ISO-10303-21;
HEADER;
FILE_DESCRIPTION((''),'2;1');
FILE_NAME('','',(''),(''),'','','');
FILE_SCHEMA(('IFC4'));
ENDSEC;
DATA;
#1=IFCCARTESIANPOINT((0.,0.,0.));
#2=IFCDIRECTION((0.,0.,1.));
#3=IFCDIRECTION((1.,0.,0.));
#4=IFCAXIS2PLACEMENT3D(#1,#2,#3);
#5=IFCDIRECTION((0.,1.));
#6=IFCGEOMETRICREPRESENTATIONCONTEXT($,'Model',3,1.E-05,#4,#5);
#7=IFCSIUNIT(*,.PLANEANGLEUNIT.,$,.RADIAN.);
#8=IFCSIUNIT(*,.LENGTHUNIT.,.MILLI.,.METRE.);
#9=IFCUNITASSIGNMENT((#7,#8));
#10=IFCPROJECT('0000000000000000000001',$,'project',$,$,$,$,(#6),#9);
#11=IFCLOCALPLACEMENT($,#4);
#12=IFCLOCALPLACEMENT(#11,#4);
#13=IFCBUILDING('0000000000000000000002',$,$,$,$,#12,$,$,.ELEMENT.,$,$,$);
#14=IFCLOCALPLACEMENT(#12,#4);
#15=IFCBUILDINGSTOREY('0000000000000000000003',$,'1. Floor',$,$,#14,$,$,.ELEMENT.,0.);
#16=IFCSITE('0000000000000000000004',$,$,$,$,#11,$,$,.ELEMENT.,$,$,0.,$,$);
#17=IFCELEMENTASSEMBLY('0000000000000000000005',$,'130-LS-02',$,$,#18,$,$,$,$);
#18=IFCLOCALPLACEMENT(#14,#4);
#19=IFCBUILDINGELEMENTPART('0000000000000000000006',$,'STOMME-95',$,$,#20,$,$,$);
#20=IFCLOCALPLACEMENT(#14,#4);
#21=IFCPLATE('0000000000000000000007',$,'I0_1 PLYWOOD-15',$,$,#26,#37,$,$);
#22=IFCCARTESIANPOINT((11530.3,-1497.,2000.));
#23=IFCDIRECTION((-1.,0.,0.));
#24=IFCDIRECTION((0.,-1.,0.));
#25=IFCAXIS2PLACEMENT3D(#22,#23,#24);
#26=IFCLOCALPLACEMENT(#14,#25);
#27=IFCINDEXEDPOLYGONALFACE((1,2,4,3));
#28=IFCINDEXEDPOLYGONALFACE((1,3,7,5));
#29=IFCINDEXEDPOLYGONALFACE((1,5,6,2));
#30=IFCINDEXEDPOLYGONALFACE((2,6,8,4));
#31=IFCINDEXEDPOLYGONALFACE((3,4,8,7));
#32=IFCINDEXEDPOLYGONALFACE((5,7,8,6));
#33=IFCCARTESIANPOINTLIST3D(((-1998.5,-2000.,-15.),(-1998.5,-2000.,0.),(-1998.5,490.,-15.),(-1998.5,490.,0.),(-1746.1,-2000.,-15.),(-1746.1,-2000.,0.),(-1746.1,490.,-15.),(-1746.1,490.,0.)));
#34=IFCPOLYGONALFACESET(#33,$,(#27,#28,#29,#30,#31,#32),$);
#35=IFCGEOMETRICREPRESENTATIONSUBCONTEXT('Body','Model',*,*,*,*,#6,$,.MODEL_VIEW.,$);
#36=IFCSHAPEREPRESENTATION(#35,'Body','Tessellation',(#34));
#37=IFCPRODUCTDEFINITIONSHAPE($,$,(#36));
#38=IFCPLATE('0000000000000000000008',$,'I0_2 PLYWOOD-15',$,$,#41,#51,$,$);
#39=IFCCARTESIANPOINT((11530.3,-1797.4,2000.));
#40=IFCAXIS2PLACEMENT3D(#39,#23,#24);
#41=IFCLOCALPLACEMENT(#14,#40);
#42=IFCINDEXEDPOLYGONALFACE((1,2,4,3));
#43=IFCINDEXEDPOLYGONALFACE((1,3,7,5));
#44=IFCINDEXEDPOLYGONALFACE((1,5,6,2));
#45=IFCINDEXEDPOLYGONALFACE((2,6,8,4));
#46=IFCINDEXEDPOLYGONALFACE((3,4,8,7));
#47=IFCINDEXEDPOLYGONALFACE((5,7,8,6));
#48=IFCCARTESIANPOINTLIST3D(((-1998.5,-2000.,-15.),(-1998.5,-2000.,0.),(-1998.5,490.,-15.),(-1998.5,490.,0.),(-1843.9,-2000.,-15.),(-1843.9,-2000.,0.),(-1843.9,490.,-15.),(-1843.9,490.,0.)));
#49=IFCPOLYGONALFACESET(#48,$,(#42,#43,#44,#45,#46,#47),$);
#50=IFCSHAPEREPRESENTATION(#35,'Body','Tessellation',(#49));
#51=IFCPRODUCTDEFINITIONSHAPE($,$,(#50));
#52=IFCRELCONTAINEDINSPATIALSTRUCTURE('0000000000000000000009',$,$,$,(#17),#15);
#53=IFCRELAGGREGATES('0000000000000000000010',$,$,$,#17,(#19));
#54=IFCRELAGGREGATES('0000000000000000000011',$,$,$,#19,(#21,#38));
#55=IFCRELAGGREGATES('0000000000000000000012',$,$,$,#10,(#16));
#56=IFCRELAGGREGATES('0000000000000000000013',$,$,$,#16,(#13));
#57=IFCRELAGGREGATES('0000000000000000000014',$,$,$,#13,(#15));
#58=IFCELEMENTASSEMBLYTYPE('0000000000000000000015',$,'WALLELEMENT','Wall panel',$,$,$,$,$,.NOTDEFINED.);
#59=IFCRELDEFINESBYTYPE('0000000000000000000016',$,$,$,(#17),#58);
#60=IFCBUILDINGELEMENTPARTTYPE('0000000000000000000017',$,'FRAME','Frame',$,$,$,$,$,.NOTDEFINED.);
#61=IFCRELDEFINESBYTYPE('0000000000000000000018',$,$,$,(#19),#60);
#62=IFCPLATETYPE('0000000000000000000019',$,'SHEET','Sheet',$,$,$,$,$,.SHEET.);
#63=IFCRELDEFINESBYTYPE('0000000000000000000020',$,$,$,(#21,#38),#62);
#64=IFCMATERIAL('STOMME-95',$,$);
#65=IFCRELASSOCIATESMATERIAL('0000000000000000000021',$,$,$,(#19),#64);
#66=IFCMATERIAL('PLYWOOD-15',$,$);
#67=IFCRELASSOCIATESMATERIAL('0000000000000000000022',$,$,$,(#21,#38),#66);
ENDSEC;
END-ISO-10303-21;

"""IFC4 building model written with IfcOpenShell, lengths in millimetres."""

from ifc_helpers import new_model, si_unit, direction, frame, origin_with_axes, origin_2d_with_axis, place, context, subcontext, project, spatial, rectangle, extrude, material, type_object, element, aggregate, save


model = new_model("IFC4")

# Units and contexts
model_context = context("Model", 3, precision=1e-05, world=origin_with_axes(), true_north=direction((0.0, 1.0)))
body_context = subcontext(model_context, "Body", "Model", "MODEL_VIEW")
ifc_project = project(units=[si_unit("PLANEANGLEUNIT", "RADIAN"), si_unit("LENGTHUNIT", "METRE", prefix="MILLI")], contexts=[model_context])

# Site, building, storey
site_placement = place(None, origin_with_axes())
site = spatial("IfcSite", under=ifc_project, at=site_placement, CompositionType="ELEMENT", RefElevation=0.0)
building_placement = place(site_placement, origin_with_axes())
building = spatial("IfcBuilding", under=site, at=building_placement, CompositionType="ELEMENT")
storey_placement = place(building_placement, origin_with_axes())
storey = spatial("IfcBuildingStorey", under=building, at=storey_placement, Name="1. Floor", CompositionType="ELEMENT", Elevation=0.0)

# Shared definitions
element_assembly_type = type_object("IfcElementAssemblyType", Name="WALLELEMENT", Description="Wall panel", PredefinedType="NOTDEFINED")

# Element assembly, building element part
assembly_1_placement = place(storey_placement, origin_with_axes())
assembly_1 = element("IfcElementAssembly", 1, at=assembly_1_placement, inside=storey, type_object=element_assembly_type, Name="130-LS-02")
ifc_material_1 = material(Name="STOMME-95")
building_element_part_type_1 = type_object("IfcBuildingElementPartType", Name="FRAME", Description="Frame", PredefinedType="NOTDEFINED")
building_element_part_1_placement = place(storey_placement, origin_with_axes())
building_element_part_1 = element("IfcBuildingElementPart", 2, at=building_element_part_1_placement, type_object=building_element_part_type_1, material=ifc_material_1, Name="STOMME-95")
aggregate(assembly_1, [building_element_part_1])

# Plates
ifc_material_2 = material(Name="PLYWOOD-15")
plate_type_1 = type_object("IfcPlateType", Name="SHEET", Description="Sheet", PredefinedType="SHEET")
plate_1_placement = place(storey_placement, frame((11530.3, -1497.0, 2000.0), z_axis=(-1.0, 0.0, 0.0), x_axis=(0.0, -1.0, 0.0)))
plate_1 = element("IfcPlate", 3, at=plate_1_placement, type_object=plate_type_1, material=ifc_material_2, Name="I0_1 PLYWOOD-15", context=body_context, shape_type="SweptSolid", body=[
    extrude(rectangle(XDim=15.0, YDim=252.4, at=origin_2d_with_axis()), frame((-1872.3, -2000.0, -7.5), z_axis=(0.0, 1.0, 0.0), x_axis=(0.0, 0.0, 1.0)), (0.0, 0.0, 1.0), 2490.0),
])
plate_2_placement = place(storey_placement, frame((11530.3, -1797.4, 2000.0), z_axis=(-1.0, 0.0, 0.0), x_axis=(0.0, -1.0, 0.0)))
plate_2 = element("IfcPlate", 4, at=plate_2_placement, type_object=plate_type_1, material=ifc_material_2, Name="I0_2 PLYWOOD-15", context=body_context, shape_type="SweptSolid", body=[
    extrude(rectangle(XDim=15.0, YDim=154.6, at=origin_2d_with_axis()), frame((-1921.2, -2000.0, -7.5), z_axis=(0.0, 1.0, 0.0), x_axis=(0.0, 0.0, 1.0)), (0.0, 0.0, 1.0), 2490.0),
])
aggregate(building_element_part_1, [plate_1, plate_2])

save(model, "model.ifc")
